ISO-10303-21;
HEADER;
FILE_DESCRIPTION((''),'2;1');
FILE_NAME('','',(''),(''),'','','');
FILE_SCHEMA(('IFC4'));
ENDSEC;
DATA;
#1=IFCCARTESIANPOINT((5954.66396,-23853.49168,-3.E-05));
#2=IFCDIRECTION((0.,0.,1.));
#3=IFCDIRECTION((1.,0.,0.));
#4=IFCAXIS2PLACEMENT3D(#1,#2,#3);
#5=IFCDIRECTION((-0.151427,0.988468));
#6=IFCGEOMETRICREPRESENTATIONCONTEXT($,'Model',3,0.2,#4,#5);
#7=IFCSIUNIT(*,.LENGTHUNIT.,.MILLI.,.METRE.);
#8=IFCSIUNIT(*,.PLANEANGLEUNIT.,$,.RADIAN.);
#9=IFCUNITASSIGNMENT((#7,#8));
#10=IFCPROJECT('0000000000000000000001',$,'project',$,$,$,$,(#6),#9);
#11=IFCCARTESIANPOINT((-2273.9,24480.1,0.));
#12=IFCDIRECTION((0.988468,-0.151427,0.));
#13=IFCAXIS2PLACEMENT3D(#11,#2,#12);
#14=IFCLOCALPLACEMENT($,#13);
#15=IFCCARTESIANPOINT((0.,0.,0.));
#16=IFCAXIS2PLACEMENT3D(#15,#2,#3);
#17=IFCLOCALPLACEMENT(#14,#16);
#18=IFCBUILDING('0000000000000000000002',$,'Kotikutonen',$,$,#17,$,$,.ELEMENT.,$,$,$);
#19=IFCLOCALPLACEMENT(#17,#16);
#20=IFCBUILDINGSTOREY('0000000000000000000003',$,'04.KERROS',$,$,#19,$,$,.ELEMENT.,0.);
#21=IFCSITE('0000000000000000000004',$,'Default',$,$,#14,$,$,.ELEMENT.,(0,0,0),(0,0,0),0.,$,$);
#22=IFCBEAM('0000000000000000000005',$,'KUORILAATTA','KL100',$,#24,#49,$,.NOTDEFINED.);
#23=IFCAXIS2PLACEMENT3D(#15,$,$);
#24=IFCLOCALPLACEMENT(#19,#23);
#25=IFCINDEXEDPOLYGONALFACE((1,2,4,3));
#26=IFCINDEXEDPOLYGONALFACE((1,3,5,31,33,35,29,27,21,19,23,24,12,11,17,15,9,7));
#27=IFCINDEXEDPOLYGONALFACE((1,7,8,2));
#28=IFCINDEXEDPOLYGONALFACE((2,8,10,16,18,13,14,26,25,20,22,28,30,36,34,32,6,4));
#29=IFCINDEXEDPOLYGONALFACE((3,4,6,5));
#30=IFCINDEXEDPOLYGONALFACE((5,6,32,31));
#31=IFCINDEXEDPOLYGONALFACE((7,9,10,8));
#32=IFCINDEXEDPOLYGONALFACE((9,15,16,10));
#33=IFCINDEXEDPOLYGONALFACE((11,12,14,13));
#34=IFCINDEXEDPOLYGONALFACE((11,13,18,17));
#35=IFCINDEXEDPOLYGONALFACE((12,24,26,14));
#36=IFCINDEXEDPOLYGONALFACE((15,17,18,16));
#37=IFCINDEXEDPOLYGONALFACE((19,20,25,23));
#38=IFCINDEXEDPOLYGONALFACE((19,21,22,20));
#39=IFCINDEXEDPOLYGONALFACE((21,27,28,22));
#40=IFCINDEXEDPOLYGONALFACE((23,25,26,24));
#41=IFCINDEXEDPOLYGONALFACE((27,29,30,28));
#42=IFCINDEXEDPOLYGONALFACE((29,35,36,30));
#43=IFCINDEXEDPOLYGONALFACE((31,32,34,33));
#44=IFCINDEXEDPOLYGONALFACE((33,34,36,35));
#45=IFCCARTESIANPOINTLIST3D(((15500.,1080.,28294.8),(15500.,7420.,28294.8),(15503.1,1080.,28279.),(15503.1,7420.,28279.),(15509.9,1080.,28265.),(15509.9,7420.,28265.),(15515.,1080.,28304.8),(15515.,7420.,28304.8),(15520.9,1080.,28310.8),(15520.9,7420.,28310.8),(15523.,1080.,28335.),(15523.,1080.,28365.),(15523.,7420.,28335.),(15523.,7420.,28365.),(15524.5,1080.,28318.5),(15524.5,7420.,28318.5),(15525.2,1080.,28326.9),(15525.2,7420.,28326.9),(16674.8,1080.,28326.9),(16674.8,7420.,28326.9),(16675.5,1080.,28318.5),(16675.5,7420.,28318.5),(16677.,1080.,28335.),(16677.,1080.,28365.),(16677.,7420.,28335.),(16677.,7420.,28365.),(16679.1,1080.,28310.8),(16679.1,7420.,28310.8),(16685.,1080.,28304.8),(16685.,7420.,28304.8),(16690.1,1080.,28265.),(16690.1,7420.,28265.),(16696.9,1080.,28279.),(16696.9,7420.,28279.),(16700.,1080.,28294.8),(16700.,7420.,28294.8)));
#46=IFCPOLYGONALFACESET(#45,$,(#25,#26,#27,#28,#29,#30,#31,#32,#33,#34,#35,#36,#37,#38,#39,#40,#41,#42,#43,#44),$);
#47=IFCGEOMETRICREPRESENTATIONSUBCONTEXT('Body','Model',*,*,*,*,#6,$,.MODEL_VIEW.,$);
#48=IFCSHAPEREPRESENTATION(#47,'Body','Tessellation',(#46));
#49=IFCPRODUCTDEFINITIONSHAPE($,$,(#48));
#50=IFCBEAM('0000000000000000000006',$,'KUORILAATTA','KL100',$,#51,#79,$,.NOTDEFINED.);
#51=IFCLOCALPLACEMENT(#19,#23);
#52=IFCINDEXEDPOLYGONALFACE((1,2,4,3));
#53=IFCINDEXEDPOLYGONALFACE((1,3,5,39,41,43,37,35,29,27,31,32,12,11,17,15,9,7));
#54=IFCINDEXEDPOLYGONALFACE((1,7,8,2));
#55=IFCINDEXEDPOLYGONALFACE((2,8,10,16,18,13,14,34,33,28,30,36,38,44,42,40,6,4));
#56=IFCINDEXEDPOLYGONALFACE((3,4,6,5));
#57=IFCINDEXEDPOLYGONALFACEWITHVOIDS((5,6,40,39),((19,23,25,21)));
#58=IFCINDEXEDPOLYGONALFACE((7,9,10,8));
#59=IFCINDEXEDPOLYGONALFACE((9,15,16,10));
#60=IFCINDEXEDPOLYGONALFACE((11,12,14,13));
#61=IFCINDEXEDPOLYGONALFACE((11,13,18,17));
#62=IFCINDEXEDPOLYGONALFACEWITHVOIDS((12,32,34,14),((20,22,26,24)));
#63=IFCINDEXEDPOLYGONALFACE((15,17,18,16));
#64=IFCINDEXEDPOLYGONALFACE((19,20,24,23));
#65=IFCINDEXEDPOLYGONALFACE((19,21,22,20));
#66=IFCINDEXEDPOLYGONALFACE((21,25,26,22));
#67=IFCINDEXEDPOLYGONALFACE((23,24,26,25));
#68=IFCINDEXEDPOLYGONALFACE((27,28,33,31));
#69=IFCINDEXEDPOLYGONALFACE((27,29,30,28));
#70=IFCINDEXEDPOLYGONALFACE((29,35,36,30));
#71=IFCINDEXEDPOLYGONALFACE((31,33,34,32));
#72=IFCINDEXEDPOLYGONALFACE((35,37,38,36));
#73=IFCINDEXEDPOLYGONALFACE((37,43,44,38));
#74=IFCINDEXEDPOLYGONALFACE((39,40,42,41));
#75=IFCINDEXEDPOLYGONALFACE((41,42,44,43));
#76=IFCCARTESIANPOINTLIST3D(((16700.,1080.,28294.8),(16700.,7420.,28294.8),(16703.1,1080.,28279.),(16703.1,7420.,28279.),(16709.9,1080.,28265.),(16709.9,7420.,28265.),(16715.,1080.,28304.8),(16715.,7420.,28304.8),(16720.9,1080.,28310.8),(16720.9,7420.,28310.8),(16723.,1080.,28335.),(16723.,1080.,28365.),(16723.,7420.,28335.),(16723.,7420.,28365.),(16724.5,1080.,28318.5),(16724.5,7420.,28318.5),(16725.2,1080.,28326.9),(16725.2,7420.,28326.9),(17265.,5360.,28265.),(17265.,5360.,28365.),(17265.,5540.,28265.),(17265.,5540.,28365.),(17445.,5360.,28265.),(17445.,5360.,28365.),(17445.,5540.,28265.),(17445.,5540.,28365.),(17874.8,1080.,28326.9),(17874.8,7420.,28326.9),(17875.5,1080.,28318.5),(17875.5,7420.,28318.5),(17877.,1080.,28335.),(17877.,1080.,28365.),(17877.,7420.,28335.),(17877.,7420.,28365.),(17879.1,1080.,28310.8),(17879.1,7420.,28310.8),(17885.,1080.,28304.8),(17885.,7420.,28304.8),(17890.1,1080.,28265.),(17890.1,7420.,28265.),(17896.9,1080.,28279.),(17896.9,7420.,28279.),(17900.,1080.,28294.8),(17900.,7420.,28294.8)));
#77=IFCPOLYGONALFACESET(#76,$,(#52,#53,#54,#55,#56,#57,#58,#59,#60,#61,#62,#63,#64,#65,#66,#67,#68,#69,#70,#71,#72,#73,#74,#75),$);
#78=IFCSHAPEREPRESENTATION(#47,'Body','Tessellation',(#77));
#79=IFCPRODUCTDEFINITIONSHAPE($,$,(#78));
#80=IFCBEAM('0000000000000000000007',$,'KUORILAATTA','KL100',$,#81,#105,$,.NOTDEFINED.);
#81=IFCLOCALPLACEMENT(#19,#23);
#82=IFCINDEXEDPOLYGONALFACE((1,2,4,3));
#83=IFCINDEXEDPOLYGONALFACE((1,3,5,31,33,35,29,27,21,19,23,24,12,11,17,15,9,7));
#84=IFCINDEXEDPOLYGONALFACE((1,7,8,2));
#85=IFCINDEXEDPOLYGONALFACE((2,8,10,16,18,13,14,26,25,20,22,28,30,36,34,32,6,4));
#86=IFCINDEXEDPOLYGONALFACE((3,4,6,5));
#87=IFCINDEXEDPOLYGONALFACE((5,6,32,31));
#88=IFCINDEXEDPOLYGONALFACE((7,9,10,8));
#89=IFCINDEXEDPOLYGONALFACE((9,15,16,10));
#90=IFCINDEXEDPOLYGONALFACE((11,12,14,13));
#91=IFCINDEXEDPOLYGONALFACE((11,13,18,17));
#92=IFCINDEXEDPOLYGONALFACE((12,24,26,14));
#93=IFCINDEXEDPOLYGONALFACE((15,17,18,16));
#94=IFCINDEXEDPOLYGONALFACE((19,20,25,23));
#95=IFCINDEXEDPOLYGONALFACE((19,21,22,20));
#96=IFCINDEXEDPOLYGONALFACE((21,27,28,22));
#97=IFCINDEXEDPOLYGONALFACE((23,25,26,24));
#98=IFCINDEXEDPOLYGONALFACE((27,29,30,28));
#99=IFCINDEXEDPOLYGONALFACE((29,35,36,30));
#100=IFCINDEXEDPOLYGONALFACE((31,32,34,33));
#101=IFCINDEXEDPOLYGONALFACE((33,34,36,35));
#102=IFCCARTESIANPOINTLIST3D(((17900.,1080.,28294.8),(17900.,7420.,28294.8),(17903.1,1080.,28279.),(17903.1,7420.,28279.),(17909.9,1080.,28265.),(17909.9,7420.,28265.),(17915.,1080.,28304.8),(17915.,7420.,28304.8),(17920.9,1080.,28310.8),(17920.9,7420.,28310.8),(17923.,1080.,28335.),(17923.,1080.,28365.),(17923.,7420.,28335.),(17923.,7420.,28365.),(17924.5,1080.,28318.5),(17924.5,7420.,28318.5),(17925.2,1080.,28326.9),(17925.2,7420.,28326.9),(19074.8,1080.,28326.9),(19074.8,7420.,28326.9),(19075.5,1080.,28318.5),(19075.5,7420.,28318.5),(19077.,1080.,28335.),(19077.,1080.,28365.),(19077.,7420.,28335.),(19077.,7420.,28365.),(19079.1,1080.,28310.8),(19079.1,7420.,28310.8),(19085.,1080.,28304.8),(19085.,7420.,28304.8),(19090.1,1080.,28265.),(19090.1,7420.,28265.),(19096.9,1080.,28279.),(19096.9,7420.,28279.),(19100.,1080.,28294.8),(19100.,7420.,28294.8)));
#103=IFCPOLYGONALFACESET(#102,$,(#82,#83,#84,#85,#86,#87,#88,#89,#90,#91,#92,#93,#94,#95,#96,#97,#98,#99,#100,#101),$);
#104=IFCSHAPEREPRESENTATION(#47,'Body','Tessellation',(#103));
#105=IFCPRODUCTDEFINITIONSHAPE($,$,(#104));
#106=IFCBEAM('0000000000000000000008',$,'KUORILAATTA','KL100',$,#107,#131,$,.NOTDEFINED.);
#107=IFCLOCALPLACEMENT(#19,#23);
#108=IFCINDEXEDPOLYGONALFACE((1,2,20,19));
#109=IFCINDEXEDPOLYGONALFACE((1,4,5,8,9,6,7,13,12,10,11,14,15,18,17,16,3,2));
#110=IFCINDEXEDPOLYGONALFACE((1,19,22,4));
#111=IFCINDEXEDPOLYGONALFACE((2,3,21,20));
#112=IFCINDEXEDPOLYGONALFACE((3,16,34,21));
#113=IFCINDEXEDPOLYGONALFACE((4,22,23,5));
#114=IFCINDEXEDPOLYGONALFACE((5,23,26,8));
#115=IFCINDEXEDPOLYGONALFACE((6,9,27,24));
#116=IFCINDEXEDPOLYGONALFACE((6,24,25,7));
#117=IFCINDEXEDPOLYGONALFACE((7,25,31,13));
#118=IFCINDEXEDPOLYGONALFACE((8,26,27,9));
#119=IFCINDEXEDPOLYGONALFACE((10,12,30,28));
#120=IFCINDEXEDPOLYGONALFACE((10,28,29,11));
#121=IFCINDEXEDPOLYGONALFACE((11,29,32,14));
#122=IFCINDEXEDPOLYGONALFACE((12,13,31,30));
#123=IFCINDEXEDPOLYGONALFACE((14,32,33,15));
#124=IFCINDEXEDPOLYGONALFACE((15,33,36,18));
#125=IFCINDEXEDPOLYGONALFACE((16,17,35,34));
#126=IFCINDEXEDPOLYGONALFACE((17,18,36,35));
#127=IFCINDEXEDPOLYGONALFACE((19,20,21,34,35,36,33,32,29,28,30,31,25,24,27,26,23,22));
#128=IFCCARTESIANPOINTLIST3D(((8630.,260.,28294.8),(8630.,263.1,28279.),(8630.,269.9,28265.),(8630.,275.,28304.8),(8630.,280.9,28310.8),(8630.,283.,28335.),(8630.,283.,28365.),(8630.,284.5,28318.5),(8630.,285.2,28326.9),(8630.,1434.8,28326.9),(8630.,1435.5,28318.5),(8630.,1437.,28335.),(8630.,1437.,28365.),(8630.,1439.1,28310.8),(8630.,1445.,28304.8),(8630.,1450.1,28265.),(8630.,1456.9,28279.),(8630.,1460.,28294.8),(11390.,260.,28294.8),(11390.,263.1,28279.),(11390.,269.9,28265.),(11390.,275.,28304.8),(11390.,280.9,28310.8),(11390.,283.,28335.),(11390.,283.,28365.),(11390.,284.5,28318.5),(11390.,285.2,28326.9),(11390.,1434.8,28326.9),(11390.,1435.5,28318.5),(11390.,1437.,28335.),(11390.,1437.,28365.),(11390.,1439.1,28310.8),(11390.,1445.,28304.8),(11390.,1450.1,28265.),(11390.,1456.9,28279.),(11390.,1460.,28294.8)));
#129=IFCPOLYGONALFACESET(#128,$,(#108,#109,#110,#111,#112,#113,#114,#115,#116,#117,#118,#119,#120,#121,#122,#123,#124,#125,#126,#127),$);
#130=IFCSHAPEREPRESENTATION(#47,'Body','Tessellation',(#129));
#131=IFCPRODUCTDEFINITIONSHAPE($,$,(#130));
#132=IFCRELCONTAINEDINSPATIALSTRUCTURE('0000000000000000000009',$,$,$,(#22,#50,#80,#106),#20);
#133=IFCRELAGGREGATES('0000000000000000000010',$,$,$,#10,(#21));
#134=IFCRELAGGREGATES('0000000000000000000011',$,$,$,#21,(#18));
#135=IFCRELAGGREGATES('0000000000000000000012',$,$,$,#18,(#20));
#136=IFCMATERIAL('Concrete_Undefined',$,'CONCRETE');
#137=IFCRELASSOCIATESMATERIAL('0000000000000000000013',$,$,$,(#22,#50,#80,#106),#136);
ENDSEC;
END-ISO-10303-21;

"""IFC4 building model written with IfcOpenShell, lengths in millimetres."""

from ifc_helpers import new_model, si_unit, direction, frame, origin_with_axes, place, context, subcontext, project, spatial, line, indexed_curve, outline, extrude, material, element, save


model = new_model("IFC4")

# Units and contexts
model_context = context("Model", 3, precision=0.2, world=frame((5954.66396, -23853.49168, -3e-05), z_axis=(0.0, 0.0, 1.0), x_axis=(1.0, 0.0, 0.0)), true_north=direction((-0.151427, 0.988468)))
body_context = subcontext(model_context, "Body", "Model", "MODEL_VIEW")
ifc_project = project(units=[si_unit("LENGTHUNIT", "METRE", prefix="MILLI"), si_unit("PLANEANGLEUNIT", "RADIAN")], contexts=[model_context])

# Site, building, storey
site_placement = place(None, frame((-2273.9, 24480.1, 0.0), z_axis=(0.0, 0.0, 1.0), x_axis=(0.988468, -0.151427, 0.0)))
site = spatial("IfcSite", under=ifc_project, at=site_placement, Name="Default", CompositionType="ELEMENT", RefLatitude=(0, 0, 0), RefLongitude=(0, 0, 0), RefElevation=0.0)
building_placement = place(site_placement, origin_with_axes())
building = spatial("IfcBuilding", under=site, at=building_placement, Name="Kotikutonen", CompositionType="ELEMENT")
storey_placement = place(building_placement, origin_with_axes())
storey = spatial("IfcBuildingStorey", under=building, at=storey_placement, Name="04.KERROS", CompositionType="ELEMENT", Elevation=0.0)

# Shared definitions
ifc_material_1 = material(Name="Concrete_Undefined", Category="CONCRETE")

# Beam
beam_1_placement = place(storey_placement, frame((16100.0, 7420.0, 28315.0), z_axis=(-1.0, 0.0, 0.0), x_axis=(0.0, -1.0, 0.0)))
element("IfcBeam", 1, at=beam_1_placement, inside=storey, material=ifc_material_1, Name="KUORILAATTA", Description="KL100", PredefinedType="NOTDEFINED", context=body_context, shape_type="SolidModel", body=[
    extrude(outline(indexed_curve([(-596.9, -36.0), (-590.1, -50.0), (590.1, -50.0), (596.9, -36.0), (600.0, -20.2), (585.0, -10.2), (579.1, -4.2), (575.5, 3.5), (574.8, 11.9), (577.0, 20.0), (577.0, 50.0), (-577.0, 50.0), (-577.0, 20.0), (-574.8, 11.9), (-575.5, 3.5), (-579.1, -4.2), (-585.0, -10.2), (-600.0, -20.2)], segments=[line(1, 2, 3, 4, 5, 6, 7, 8, 9, 10, 11, 12, 13, 14, 15, 16, 17, 18, 1)])), frame((0.0, 0.0, 0.0), z_axis=(-1.0, 0.0, 0.0), x_axis=(0.0, 0.0, 1.0)), (0.0, 0.0, -1.0), 6340.0),
])

# Beam, voiding feature
beam_2_placement = place(storey_placement, frame((17300.0, 7420.0, 28315.0), z_axis=(-1.0, 0.0, 0.0), x_axis=(0.0, -1.0, 0.0)))
beam_2 = element("IfcBeam", 2, at=beam_2_placement, inside=storey, material=ifc_material_1, Name="KUORILAATTA", Description="KL100", PredefinedType="NOTDEFINED", context=body_context, shape_type="SolidModel", body=[
    extrude(outline(indexed_curve([(-596.9, -36.0), (-590.1, -50.0), (590.1, -50.0), (596.9, -36.0), (600.0, -20.2), (585.0, -10.2), (579.1, -4.2), (575.5, 3.5), (574.8, 11.9), (577.0, 20.0), (577.0, 50.0), (-577.0, 50.0), (-577.0, 20.0), (-574.8, 11.9), (-575.5, 3.5), (-579.1, -4.2), (-585.0, -10.2), (-600.0, -20.2)], segments=[line(1, 2, 3, 4, 5, 6, 7, 8, 9, 10, 11, 12, 13, 14, 15, 16, 17, 18, 1)])), frame((0.0, 0.0, 0.0), z_axis=(-1.0, 0.0, 0.0), x_axis=(0.0, 0.0, 1.0)), (0.0, 0.0, -1.0), 6340.0),
])
voiding_feature_1_placement = place(beam_2_placement, frame((1880.0, 0.0, -145.0), z_axis=(0.0, 1.0, 0.0), x_axis=(0.0, 0.0, 1.0)))
element("IfcVoidingFeature", 3, at=voiding_feature_1_placement, cuts=beam_2, Name="Opening", PredefinedType="HOLE", context=body_context, shape_type="SolidModel", body=[
    extrude(outline(indexed_curve([(0.0, 0.0), (180.0, 0.0), (180.0, 180.0), (0.0, 180.0)], segments=[line(1, 2, 3, 4, 1)])), frame((0.0, 0.0, 125.0), z_axis=(0.0, 0.0, 1.0), x_axis=(1.0, 0.0, 0.0)), (0.0, 0.0, -1.0), 250.0),
])

# Beams
beam_3_placement = place(storey_placement, frame((18500.0, 7420.0, 28315.0), z_axis=(-1.0, 0.0, 0.0), x_axis=(0.0, -1.0, 0.0)))
element("IfcBeam", 4, at=beam_3_placement, inside=storey, material=ifc_material_1, Name="KUORILAATTA", Description="KL100", PredefinedType="NOTDEFINED", context=body_context, shape_type="SolidModel", body=[
    extrude(outline(indexed_curve([(-596.9, -36.0), (-590.1, -50.0), (590.1, -50.0), (596.9, -36.0), (600.0, -20.2), (585.0, -10.2), (579.1, -4.2), (575.5, 3.5), (574.8, 11.9), (577.0, 20.0), (577.0, 50.0), (-577.0, 50.0), (-577.0, 20.0), (-574.8, 11.9), (-575.5, 3.5), (-579.1, -4.2), (-585.0, -10.2), (-600.0, -20.2)], segments=[line(1, 2, 3, 4, 5, 6, 7, 8, 9, 10, 11, 12, 13, 14, 15, 16, 17, 18, 1)])), frame((0.0, 0.0, 0.0), z_axis=(-1.0, 0.0, 0.0), x_axis=(0.0, 0.0, 1.0)), (0.0, 0.0, -1.0), 6340.0),
])
beam_4_placement = place(storey_placement, frame((11390.0, 860.0, 28315.0), z_axis=(0.0, 1.0, 0.0), x_axis=(-1.0, 0.0, 0.0)))
element("IfcBeam", 5, at=beam_4_placement, inside=storey, material=ifc_material_1, Name="KUORILAATTA", Description="KL100", PredefinedType="NOTDEFINED", context=body_context, shape_type="SolidModel", body=[
    extrude(outline(indexed_curve([(-596.9, -36.0), (-590.1, -50.0), (590.1, -50.0), (596.9, -36.0), (600.0, -20.2), (585.0, -10.2), (579.1, -4.2), (575.5, 3.5), (574.8, 11.9), (577.0, 20.0), (577.0, 50.0), (-577.0, 50.0), (-577.0, 20.0), (-574.8, 11.9), (-575.5, 3.5), (-579.1, -4.2), (-585.0, -10.2), (-600.0, -20.2)], segments=[line(1, 2, 3, 4, 5, 6, 7, 8, 9, 10, 11, 12, 13, 14, 15, 16, 17, 18, 1)])), frame((0.0, 0.0, 0.0), z_axis=(-1.0, 0.0, 0.0), x_axis=(0.0, 0.0, 1.0)), (0.0, 0.0, -1.0), 2760.0),
])

save(model, "model.ifc")
